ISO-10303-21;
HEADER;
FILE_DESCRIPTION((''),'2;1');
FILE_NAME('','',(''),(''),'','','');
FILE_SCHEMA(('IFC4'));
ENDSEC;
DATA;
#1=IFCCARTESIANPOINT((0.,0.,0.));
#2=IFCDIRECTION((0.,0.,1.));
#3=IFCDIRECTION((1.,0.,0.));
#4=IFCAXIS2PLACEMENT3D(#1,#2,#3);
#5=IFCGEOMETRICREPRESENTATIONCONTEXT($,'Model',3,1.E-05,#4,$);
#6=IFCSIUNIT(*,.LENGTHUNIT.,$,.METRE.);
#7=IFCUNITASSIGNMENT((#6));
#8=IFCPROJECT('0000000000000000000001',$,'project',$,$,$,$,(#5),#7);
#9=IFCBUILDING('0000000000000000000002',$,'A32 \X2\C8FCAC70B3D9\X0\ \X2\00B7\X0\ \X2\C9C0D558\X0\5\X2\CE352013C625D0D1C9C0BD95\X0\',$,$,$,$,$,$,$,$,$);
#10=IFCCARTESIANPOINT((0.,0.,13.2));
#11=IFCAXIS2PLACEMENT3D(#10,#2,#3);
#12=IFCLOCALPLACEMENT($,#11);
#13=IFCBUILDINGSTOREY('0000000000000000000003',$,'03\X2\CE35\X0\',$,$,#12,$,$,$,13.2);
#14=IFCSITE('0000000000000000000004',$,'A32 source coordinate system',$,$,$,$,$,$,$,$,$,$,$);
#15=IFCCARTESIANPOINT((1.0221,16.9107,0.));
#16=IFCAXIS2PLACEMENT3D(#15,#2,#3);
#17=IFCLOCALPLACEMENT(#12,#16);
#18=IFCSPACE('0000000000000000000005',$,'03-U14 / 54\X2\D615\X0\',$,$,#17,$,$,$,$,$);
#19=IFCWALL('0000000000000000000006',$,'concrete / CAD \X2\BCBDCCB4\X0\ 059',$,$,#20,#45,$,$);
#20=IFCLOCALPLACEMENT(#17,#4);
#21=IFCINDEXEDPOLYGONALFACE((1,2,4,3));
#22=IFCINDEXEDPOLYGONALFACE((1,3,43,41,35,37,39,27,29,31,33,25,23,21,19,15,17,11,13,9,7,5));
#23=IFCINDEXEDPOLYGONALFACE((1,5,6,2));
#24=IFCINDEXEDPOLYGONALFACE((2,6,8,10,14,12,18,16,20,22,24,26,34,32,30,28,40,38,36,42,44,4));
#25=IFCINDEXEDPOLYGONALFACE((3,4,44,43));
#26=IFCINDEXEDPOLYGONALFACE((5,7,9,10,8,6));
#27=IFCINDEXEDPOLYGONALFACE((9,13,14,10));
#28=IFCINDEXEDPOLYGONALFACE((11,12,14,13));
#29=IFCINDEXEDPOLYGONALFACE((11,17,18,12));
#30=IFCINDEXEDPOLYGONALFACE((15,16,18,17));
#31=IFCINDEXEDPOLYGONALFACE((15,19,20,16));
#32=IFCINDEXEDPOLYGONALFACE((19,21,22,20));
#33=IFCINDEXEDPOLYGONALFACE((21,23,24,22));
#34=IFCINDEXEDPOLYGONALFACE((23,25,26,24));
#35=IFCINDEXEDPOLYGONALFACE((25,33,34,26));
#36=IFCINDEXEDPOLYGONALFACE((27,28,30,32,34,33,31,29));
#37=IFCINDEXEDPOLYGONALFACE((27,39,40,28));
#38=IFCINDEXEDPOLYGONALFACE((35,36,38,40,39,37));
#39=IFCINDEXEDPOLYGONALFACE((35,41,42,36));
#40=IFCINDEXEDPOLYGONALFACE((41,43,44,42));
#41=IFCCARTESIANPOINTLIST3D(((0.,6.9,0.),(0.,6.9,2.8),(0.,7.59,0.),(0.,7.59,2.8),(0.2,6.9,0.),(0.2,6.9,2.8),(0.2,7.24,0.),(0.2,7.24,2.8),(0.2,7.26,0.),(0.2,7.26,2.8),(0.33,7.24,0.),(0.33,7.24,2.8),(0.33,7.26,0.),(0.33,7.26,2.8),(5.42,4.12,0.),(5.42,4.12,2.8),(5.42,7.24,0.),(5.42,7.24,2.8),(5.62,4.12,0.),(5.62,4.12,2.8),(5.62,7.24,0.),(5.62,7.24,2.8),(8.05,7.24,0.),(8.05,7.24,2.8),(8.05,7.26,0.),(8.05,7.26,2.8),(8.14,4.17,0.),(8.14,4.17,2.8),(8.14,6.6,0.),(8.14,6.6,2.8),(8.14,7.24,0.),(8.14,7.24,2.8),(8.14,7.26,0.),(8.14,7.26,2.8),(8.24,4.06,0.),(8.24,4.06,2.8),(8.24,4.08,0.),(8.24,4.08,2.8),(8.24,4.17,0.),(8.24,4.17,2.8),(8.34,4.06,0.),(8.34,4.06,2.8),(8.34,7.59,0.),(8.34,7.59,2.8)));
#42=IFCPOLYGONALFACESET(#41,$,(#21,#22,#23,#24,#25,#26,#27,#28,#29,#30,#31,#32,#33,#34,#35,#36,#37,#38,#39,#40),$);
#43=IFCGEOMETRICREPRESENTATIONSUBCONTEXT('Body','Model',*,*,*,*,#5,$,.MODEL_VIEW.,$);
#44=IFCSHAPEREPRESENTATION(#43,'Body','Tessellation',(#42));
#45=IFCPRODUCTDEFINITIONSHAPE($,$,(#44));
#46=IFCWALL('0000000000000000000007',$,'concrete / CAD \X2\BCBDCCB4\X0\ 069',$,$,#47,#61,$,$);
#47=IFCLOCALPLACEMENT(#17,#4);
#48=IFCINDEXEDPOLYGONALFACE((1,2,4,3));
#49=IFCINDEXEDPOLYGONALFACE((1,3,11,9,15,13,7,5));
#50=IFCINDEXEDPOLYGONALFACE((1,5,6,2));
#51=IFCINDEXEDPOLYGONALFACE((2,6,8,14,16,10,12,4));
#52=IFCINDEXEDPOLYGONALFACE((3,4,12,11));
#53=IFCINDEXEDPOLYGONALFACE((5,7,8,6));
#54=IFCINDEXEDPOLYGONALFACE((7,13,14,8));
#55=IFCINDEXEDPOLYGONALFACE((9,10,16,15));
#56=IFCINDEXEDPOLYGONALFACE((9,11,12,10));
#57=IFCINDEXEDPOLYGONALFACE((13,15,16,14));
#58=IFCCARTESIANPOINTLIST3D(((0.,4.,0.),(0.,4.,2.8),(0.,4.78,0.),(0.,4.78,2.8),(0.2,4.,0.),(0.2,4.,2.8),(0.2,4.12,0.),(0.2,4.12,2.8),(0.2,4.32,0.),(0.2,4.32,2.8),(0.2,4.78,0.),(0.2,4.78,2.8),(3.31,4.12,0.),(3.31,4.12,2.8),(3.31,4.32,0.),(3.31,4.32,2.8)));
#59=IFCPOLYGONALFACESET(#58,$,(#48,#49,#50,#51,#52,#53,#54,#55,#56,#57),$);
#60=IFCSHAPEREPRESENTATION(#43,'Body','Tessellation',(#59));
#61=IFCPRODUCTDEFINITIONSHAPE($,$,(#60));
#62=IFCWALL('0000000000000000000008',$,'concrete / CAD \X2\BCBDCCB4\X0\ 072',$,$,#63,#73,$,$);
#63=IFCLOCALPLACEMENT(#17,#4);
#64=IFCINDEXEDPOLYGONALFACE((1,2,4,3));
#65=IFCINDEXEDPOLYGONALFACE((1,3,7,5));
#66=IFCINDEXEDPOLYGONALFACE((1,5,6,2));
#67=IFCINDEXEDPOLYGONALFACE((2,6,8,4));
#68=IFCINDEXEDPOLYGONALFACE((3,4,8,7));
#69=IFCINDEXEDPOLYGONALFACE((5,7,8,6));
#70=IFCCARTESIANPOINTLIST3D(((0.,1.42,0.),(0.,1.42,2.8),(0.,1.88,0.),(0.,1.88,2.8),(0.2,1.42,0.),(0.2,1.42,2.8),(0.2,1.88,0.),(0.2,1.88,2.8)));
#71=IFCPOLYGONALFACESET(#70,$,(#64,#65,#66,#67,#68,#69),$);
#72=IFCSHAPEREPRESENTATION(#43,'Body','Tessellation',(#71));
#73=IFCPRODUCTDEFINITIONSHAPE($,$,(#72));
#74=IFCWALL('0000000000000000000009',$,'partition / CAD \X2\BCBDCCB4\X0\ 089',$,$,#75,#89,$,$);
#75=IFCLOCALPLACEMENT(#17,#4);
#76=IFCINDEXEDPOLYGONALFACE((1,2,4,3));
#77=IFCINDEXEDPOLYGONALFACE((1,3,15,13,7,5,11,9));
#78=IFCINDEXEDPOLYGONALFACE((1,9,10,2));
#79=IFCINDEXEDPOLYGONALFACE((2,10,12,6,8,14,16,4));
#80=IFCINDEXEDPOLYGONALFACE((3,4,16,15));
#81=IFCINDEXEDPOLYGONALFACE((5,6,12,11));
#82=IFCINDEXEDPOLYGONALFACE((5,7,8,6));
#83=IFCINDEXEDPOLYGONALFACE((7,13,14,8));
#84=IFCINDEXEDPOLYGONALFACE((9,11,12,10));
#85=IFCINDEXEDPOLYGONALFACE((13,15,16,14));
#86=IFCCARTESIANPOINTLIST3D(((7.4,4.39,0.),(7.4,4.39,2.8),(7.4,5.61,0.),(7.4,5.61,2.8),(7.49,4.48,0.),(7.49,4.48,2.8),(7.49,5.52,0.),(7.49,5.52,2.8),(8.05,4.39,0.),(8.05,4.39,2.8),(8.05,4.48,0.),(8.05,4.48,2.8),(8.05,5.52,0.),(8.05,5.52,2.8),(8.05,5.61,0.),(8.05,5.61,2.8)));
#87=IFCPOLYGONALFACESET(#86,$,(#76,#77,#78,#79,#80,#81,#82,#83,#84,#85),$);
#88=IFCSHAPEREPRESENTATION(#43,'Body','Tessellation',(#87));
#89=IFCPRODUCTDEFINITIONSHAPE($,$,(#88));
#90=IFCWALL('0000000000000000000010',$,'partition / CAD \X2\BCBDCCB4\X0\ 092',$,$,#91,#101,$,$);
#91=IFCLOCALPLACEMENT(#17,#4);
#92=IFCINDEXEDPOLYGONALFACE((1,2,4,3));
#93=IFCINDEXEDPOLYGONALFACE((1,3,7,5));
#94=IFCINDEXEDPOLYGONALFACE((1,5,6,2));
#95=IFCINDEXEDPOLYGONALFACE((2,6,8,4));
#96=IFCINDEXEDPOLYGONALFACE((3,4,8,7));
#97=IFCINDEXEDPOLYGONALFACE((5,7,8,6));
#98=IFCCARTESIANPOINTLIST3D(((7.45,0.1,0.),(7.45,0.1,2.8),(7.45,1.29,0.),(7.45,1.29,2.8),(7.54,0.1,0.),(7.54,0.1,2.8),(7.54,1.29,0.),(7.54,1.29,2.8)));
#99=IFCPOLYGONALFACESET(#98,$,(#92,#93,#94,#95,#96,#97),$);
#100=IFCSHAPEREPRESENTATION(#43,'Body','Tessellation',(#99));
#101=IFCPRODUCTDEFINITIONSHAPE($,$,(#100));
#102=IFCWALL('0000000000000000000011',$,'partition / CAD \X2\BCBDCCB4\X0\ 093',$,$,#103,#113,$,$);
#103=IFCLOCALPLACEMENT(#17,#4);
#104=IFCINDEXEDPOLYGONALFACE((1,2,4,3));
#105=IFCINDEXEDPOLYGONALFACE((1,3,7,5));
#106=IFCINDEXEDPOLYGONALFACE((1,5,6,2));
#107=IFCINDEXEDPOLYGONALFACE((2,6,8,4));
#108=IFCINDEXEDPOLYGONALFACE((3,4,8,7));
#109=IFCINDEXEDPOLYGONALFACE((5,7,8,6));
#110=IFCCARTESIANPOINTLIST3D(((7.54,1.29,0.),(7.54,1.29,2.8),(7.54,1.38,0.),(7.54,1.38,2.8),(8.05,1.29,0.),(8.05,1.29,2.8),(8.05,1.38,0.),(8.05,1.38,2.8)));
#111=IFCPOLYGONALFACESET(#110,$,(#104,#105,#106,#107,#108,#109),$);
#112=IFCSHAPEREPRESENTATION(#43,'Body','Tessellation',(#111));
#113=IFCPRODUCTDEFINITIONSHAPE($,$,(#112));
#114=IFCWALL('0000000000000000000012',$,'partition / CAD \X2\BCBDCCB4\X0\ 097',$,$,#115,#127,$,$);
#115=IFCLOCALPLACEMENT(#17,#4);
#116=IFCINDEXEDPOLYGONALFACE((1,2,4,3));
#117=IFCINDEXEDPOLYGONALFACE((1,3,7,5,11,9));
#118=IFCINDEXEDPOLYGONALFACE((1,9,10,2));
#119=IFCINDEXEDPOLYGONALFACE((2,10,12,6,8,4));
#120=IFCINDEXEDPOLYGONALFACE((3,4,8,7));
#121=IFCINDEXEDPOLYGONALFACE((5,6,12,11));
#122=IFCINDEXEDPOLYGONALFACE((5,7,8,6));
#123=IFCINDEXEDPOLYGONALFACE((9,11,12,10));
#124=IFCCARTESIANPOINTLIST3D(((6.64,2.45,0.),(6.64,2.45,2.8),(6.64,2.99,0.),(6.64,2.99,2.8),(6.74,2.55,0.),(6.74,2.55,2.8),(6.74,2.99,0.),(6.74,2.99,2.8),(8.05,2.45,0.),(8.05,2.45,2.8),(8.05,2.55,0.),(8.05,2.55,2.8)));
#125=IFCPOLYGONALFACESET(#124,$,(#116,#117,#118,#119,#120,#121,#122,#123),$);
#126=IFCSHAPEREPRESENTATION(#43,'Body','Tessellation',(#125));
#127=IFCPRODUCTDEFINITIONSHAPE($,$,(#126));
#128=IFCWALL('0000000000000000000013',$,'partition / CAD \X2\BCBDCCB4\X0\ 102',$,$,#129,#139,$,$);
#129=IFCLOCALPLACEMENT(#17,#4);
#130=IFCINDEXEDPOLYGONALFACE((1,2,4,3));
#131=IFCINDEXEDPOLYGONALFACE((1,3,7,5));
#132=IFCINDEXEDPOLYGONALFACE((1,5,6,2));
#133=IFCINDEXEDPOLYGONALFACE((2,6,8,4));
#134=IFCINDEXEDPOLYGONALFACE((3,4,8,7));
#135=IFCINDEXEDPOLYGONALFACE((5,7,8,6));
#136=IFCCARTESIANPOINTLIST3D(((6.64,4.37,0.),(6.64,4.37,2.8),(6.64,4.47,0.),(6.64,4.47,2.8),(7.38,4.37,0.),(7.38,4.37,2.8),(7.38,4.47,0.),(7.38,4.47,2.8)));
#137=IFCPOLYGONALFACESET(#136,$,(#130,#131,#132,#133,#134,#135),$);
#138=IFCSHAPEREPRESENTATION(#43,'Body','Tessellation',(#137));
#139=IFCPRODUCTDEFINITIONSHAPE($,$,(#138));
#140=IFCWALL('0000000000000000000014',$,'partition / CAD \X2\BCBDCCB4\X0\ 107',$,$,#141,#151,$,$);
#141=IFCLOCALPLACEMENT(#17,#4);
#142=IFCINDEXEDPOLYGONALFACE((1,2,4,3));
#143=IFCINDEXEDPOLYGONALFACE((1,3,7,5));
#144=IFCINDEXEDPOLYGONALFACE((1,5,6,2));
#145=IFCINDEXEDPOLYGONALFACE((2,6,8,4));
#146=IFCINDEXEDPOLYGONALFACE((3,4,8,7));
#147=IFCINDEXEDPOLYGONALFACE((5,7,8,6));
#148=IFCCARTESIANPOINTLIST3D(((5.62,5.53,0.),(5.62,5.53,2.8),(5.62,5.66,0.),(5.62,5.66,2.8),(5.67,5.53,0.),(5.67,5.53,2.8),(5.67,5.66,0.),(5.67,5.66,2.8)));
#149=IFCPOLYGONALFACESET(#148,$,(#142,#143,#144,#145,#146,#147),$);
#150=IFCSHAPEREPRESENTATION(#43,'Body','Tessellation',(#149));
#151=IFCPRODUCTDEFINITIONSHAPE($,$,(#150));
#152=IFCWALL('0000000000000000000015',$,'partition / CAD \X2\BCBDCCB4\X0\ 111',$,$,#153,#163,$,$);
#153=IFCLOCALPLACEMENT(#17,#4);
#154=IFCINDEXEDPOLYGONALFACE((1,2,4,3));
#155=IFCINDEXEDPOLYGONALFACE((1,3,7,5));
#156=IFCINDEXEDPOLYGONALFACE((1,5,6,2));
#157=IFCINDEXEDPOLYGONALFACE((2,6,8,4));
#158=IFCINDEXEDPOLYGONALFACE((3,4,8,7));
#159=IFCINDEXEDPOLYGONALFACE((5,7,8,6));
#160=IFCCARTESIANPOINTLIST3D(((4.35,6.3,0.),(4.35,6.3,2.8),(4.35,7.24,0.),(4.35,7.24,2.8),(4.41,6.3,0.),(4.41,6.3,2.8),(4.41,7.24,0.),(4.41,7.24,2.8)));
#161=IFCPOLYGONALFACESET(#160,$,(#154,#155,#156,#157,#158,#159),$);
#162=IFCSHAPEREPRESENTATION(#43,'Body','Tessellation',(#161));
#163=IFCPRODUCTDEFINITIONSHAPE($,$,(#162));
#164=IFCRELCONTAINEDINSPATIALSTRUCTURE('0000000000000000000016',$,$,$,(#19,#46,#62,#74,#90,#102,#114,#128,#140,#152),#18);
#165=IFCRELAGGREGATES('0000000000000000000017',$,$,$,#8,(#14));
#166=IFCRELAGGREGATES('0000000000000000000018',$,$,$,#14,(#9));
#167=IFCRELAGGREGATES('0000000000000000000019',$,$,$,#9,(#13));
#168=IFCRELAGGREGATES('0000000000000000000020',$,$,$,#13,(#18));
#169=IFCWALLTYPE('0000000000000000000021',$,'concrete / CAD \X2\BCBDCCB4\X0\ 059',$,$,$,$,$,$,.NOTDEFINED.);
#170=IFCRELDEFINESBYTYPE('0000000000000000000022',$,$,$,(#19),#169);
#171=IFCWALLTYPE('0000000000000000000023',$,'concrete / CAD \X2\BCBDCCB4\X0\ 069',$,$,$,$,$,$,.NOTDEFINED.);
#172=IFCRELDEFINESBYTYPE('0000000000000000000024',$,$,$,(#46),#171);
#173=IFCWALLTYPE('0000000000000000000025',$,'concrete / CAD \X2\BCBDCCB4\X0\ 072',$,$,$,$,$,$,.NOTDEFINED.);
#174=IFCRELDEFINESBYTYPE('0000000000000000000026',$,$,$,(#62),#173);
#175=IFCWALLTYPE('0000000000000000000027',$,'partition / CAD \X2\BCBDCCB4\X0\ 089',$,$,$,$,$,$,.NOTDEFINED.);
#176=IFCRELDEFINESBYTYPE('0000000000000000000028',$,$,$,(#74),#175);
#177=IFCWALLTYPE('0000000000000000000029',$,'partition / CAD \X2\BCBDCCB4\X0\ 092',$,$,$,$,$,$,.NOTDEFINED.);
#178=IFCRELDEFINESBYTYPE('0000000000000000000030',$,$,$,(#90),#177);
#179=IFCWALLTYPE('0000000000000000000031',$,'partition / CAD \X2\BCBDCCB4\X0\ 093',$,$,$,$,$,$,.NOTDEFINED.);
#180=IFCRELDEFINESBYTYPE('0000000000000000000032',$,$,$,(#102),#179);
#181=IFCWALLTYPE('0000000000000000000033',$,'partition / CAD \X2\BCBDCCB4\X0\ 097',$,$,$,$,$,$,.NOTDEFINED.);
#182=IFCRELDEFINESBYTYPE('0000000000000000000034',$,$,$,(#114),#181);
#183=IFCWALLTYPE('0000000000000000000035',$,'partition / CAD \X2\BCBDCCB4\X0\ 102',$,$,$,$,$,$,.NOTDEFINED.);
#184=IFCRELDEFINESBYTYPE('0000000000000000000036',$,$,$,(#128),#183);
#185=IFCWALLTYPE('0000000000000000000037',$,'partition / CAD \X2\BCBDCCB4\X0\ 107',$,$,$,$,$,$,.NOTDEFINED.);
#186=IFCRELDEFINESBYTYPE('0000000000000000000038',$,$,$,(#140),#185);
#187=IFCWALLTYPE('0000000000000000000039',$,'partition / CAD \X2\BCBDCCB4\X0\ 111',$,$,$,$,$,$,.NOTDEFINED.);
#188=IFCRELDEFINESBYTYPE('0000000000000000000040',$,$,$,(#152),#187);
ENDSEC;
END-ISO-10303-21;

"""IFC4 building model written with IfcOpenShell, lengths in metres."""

from ifc_helpers import new_model, si_unit, frame, origin, origin_with_axes, place, context, subcontext, project, spatial, polyline, outline, extrude, source, transform, mapped, type_object, type_shapes, element, save


model = new_model("IFC4")

# Units and contexts
model_context = context("Model", 3, precision=1e-05, world=origin_with_axes())
body_context = subcontext(model_context, "Body", "Model", "MODEL_VIEW")
ifc_project = project(units=[si_unit("LENGTHUNIT", "METRE")], contexts=[model_context])

# Site, building, storey, space
storey_placement = place(None, frame((0.0, 0.0, 13.2), z_axis=(0.0, 0.0, 1.0), x_axis=(1.0, 0.0, 0.0)))
space_placement = place(storey_placement, frame((1.0221, 16.9107, 0.0), z_axis=(0.0, 0.0, 1.0), x_axis=(1.0, 0.0, 0.0)))
site = spatial("IfcSite", under=ifc_project, Name="A32 source coordinate system")
building = spatial("IfcBuilding", under=site, Name="A32 주거동 · 지하5층–옥탑지붕")
storey = spatial("IfcBuildingStorey", under=building, at=storey_placement, Name="03층", Elevation=13.2)
space = spatial("IfcSpace", under=storey, at=space_placement, Name="03-U14 / 54형")

# Walls
wall_type_1 = type_object("IfcWallType", Name="concrete / CAD 벽체 059", PredefinedType="NOTDEFINED")
shared_shape_1 = source(origin(), body_context, "Body", "SweptSolid", [
    extrude(outline(polyline([(8.05, 7.26), (8.05, 7.24), (5.62, 7.24), (5.62, 4.12), (5.42, 4.12), (5.42, 7.24), (0.33, 7.24), (0.33, 7.26), (0.2, 7.26), (0.2, 7.24), (0.2, 6.9), (0.0, 6.9), (0.0, 7.59), (8.34, 7.59), (8.34, 4.06), (8.24, 4.06), (8.24, 4.08), (8.24, 4.17), (8.14, 4.17), (8.14, 6.6), (8.14, 7.24), (8.14, 7.26), (8.05, 7.26)])), origin(), (0.0, 0.0, 1.0), 2.8),
])
type_shapes(wall_type_1, [shared_shape_1])
wall_1_placement = place(space_placement, origin_with_axes())
element("IfcWall", 1, at=wall_1_placement, inside=space, type_object=wall_type_1, Name="concrete / CAD 벽체 059", context=body_context, shape_type="MappedRepresentation", body=[
    mapped(shared_shape_1, transform((0.0, 0.0, 0.0), scale=1.0)),
])
wall_type_2 = type_object("IfcWallType", Name="concrete / CAD 벽체 069", PredefinedType="NOTDEFINED")
shared_shape_2 = source(origin(), body_context, "Body", "SweptSolid", [
    extrude(outline(polyline([(0.2, 4.12), (0.2, 4.0), (0.0, 4.0), (0.0, 4.78), (0.2, 4.78), (0.2, 4.32), (3.31, 4.32), (3.31, 4.12), (0.2, 4.12)])), origin(), (0.0, 0.0, 1.0), 2.8),
])
type_shapes(wall_type_2, [shared_shape_2])
wall_2_placement = place(space_placement, origin_with_axes())
element("IfcWall", 2, at=wall_2_placement, inside=space, type_object=wall_type_2, Name="concrete / CAD 벽체 069", context=body_context, shape_type="MappedRepresentation", body=[
    mapped(shared_shape_2, transform((0.0, 0.0, 0.0), scale=1.0)),
])
wall_type_3 = type_object("IfcWallType", Name="concrete / CAD 벽체 072", PredefinedType="NOTDEFINED")
shared_shape_3 = source(origin(), body_context, "Body", "SweptSolid", [
    extrude(outline(polyline([(0.2, 1.88), (0.2, 1.42), (0.0, 1.42), (0.0, 1.88), (0.2, 1.88)])), origin(), (0.0, 0.0, 1.0), 2.8),
])
type_shapes(wall_type_3, [shared_shape_3])
wall_3_placement = place(space_placement, origin_with_axes())
element("IfcWall", 3, at=wall_3_placement, inside=space, type_object=wall_type_3, Name="concrete / CAD 벽체 072", context=body_context, shape_type="MappedRepresentation", body=[
    mapped(shared_shape_3, transform((0.0, 0.0, 0.0), scale=1.0)),
])
wall_type_4 = type_object("IfcWallType", Name="partition / CAD 벽체 089", PredefinedType="NOTDEFINED")
shared_shape_4 = source(origin(), body_context, "Body", "SweptSolid", [
    extrude(outline(polyline([(7.49, 4.48), (8.05, 4.48), (8.05, 4.39), (7.4, 4.39), (7.4, 5.61), (8.05, 5.61), (8.05, 5.52), (7.49, 5.52), (7.49, 4.48)])), origin(), (0.0, 0.0, 1.0), 2.8),
])
type_shapes(wall_type_4, [shared_shape_4])
wall_4_placement = place(space_placement, origin_with_axes())
element("IfcWall", 4, at=wall_4_placement, inside=space, type_object=wall_type_4, Name="partition / CAD 벽체 089", context=body_context, shape_type="MappedRepresentation", body=[
    mapped(shared_shape_4, transform((0.0, 0.0, 0.0), scale=1.0)),
])
wall_type_5 = type_object("IfcWallType", Name="partition / CAD 벽체 092", PredefinedType="NOTDEFINED")
shared_shape_5 = source(origin(), body_context, "Body", "SweptSolid", [
    extrude(outline(polyline([(7.54, 1.29), (7.54, 0.1), (7.45, 0.1), (7.45, 1.29), (7.54, 1.29)])), origin(), (0.0, 0.0, 1.0), 2.8),
])
type_shapes(wall_type_5, [shared_shape_5])
wall_5_placement = place(space_placement, origin_with_axes())
element("IfcWall", 5, at=wall_5_placement, inside=space, type_object=wall_type_5, Name="partition / CAD 벽체 092", context=body_context, shape_type="MappedRepresentation", body=[
    mapped(shared_shape_5, transform((0.0, 0.0, 0.0), scale=1.0)),
])
wall_type_6 = type_object("IfcWallType", Name="partition / CAD 벽체 093", PredefinedType="NOTDEFINED")
shared_shape_6 = source(origin(), body_context, "Body", "SweptSolid", [
    extrude(outline(polyline([(8.05, 1.29), (7.54, 1.29), (7.54, 1.38), (8.05, 1.38), (8.05, 1.29)])), origin(), (0.0, 0.0, 1.0), 2.8),
])
type_shapes(wall_type_6, [shared_shape_6])
wall_6_placement = place(space_placement, origin_with_axes())
element("IfcWall", 6, at=wall_6_placement, inside=space, type_object=wall_type_6, Name="partition / CAD 벽체 093", context=body_context, shape_type="MappedRepresentation", body=[
    mapped(shared_shape_6, transform((0.0, 0.0, 0.0), scale=1.0)),
])
wall_type_7 = type_object("IfcWallType", Name="partition / CAD 벽체 097", PredefinedType="NOTDEFINED")
shared_shape_7 = source(origin(), body_context, "Body", "SweptSolid", [
    extrude(outline(polyline([(8.05, 2.45), (6.64, 2.45), (6.64, 2.99), (6.74, 2.99), (6.74, 2.55), (8.05, 2.55), (8.05, 2.45)])), origin(), (0.0, 0.0, 1.0), 2.8),
])
type_shapes(wall_type_7, [shared_shape_7])
wall_7_placement = place(space_placement, origin_with_axes())
element("IfcWall", 7, at=wall_7_placement, inside=space, type_object=wall_type_7, Name="partition / CAD 벽체 097", context=body_context, shape_type="MappedRepresentation", body=[
    mapped(shared_shape_7, transform((0.0, 0.0, 0.0), scale=1.0)),
])
wall_type_8 = type_object("IfcWallType", Name="partition / CAD 벽체 102", PredefinedType="NOTDEFINED")
shared_shape_8 = source(origin(), body_context, "Body", "SweptSolid", [
    extrude(outline(polyline([(7.38, 4.47), (7.38, 4.37), (6.64, 4.37), (6.64, 4.47), (7.38, 4.47)])), origin(), (0.0, 0.0, 1.0), 2.8),
])
type_shapes(wall_type_8, [shared_shape_8])
wall_8_placement = place(space_placement, origin_with_axes())
element("IfcWall", 8, at=wall_8_placement, inside=space, type_object=wall_type_8, Name="partition / CAD 벽체 102", context=body_context, shape_type="MappedRepresentation", body=[
    mapped(shared_shape_8, transform((0.0, 0.0, 0.0), scale=1.0)),
])
wall_type_9 = type_object("IfcWallType", Name="partition / CAD 벽체 107", PredefinedType="NOTDEFINED")
shared_shape_9 = source(origin(), body_context, "Body", "SweptSolid", [
    extrude(outline(polyline([(5.62, 5.53), (5.62, 5.66), (5.67, 5.66), (5.67, 5.53), (5.62, 5.53)])), origin(), (0.0, 0.0, 1.0), 2.8),
])
type_shapes(wall_type_9, [shared_shape_9])
wall_9_placement = place(space_placement, origin_with_axes())
element("IfcWall", 9, at=wall_9_placement, inside=space, type_object=wall_type_9, Name="partition / CAD 벽체 107", context=body_context, shape_type="MappedRepresentation", body=[
    mapped(shared_shape_9, transform((0.0, 0.0, 0.0), scale=1.0)),
])
wall_type_10 = type_object("IfcWallType", Name="partition / CAD 벽체 111", PredefinedType="NOTDEFINED")
shared_shape_10 = source(origin(), body_context, "Body", "SweptSolid", [
    extrude(outline(polyline([(4.41, 7.24), (4.41, 6.3), (4.35, 6.3), (4.35, 7.24), (4.41, 7.24)])), origin(), (0.0, 0.0, 1.0), 2.8),
])
type_shapes(wall_type_10, [shared_shape_10])
wall_10_placement = place(space_placement, origin_with_axes())
element("IfcWall", 10, at=wall_10_placement, inside=space, type_object=wall_type_10, Name="partition / CAD 벽체 111", context=body_context, shape_type="MappedRepresentation", body=[
    mapped(shared_shape_10, transform((0.0, 0.0, 0.0), scale=1.0)),
])

save(model, "model.ifc")
